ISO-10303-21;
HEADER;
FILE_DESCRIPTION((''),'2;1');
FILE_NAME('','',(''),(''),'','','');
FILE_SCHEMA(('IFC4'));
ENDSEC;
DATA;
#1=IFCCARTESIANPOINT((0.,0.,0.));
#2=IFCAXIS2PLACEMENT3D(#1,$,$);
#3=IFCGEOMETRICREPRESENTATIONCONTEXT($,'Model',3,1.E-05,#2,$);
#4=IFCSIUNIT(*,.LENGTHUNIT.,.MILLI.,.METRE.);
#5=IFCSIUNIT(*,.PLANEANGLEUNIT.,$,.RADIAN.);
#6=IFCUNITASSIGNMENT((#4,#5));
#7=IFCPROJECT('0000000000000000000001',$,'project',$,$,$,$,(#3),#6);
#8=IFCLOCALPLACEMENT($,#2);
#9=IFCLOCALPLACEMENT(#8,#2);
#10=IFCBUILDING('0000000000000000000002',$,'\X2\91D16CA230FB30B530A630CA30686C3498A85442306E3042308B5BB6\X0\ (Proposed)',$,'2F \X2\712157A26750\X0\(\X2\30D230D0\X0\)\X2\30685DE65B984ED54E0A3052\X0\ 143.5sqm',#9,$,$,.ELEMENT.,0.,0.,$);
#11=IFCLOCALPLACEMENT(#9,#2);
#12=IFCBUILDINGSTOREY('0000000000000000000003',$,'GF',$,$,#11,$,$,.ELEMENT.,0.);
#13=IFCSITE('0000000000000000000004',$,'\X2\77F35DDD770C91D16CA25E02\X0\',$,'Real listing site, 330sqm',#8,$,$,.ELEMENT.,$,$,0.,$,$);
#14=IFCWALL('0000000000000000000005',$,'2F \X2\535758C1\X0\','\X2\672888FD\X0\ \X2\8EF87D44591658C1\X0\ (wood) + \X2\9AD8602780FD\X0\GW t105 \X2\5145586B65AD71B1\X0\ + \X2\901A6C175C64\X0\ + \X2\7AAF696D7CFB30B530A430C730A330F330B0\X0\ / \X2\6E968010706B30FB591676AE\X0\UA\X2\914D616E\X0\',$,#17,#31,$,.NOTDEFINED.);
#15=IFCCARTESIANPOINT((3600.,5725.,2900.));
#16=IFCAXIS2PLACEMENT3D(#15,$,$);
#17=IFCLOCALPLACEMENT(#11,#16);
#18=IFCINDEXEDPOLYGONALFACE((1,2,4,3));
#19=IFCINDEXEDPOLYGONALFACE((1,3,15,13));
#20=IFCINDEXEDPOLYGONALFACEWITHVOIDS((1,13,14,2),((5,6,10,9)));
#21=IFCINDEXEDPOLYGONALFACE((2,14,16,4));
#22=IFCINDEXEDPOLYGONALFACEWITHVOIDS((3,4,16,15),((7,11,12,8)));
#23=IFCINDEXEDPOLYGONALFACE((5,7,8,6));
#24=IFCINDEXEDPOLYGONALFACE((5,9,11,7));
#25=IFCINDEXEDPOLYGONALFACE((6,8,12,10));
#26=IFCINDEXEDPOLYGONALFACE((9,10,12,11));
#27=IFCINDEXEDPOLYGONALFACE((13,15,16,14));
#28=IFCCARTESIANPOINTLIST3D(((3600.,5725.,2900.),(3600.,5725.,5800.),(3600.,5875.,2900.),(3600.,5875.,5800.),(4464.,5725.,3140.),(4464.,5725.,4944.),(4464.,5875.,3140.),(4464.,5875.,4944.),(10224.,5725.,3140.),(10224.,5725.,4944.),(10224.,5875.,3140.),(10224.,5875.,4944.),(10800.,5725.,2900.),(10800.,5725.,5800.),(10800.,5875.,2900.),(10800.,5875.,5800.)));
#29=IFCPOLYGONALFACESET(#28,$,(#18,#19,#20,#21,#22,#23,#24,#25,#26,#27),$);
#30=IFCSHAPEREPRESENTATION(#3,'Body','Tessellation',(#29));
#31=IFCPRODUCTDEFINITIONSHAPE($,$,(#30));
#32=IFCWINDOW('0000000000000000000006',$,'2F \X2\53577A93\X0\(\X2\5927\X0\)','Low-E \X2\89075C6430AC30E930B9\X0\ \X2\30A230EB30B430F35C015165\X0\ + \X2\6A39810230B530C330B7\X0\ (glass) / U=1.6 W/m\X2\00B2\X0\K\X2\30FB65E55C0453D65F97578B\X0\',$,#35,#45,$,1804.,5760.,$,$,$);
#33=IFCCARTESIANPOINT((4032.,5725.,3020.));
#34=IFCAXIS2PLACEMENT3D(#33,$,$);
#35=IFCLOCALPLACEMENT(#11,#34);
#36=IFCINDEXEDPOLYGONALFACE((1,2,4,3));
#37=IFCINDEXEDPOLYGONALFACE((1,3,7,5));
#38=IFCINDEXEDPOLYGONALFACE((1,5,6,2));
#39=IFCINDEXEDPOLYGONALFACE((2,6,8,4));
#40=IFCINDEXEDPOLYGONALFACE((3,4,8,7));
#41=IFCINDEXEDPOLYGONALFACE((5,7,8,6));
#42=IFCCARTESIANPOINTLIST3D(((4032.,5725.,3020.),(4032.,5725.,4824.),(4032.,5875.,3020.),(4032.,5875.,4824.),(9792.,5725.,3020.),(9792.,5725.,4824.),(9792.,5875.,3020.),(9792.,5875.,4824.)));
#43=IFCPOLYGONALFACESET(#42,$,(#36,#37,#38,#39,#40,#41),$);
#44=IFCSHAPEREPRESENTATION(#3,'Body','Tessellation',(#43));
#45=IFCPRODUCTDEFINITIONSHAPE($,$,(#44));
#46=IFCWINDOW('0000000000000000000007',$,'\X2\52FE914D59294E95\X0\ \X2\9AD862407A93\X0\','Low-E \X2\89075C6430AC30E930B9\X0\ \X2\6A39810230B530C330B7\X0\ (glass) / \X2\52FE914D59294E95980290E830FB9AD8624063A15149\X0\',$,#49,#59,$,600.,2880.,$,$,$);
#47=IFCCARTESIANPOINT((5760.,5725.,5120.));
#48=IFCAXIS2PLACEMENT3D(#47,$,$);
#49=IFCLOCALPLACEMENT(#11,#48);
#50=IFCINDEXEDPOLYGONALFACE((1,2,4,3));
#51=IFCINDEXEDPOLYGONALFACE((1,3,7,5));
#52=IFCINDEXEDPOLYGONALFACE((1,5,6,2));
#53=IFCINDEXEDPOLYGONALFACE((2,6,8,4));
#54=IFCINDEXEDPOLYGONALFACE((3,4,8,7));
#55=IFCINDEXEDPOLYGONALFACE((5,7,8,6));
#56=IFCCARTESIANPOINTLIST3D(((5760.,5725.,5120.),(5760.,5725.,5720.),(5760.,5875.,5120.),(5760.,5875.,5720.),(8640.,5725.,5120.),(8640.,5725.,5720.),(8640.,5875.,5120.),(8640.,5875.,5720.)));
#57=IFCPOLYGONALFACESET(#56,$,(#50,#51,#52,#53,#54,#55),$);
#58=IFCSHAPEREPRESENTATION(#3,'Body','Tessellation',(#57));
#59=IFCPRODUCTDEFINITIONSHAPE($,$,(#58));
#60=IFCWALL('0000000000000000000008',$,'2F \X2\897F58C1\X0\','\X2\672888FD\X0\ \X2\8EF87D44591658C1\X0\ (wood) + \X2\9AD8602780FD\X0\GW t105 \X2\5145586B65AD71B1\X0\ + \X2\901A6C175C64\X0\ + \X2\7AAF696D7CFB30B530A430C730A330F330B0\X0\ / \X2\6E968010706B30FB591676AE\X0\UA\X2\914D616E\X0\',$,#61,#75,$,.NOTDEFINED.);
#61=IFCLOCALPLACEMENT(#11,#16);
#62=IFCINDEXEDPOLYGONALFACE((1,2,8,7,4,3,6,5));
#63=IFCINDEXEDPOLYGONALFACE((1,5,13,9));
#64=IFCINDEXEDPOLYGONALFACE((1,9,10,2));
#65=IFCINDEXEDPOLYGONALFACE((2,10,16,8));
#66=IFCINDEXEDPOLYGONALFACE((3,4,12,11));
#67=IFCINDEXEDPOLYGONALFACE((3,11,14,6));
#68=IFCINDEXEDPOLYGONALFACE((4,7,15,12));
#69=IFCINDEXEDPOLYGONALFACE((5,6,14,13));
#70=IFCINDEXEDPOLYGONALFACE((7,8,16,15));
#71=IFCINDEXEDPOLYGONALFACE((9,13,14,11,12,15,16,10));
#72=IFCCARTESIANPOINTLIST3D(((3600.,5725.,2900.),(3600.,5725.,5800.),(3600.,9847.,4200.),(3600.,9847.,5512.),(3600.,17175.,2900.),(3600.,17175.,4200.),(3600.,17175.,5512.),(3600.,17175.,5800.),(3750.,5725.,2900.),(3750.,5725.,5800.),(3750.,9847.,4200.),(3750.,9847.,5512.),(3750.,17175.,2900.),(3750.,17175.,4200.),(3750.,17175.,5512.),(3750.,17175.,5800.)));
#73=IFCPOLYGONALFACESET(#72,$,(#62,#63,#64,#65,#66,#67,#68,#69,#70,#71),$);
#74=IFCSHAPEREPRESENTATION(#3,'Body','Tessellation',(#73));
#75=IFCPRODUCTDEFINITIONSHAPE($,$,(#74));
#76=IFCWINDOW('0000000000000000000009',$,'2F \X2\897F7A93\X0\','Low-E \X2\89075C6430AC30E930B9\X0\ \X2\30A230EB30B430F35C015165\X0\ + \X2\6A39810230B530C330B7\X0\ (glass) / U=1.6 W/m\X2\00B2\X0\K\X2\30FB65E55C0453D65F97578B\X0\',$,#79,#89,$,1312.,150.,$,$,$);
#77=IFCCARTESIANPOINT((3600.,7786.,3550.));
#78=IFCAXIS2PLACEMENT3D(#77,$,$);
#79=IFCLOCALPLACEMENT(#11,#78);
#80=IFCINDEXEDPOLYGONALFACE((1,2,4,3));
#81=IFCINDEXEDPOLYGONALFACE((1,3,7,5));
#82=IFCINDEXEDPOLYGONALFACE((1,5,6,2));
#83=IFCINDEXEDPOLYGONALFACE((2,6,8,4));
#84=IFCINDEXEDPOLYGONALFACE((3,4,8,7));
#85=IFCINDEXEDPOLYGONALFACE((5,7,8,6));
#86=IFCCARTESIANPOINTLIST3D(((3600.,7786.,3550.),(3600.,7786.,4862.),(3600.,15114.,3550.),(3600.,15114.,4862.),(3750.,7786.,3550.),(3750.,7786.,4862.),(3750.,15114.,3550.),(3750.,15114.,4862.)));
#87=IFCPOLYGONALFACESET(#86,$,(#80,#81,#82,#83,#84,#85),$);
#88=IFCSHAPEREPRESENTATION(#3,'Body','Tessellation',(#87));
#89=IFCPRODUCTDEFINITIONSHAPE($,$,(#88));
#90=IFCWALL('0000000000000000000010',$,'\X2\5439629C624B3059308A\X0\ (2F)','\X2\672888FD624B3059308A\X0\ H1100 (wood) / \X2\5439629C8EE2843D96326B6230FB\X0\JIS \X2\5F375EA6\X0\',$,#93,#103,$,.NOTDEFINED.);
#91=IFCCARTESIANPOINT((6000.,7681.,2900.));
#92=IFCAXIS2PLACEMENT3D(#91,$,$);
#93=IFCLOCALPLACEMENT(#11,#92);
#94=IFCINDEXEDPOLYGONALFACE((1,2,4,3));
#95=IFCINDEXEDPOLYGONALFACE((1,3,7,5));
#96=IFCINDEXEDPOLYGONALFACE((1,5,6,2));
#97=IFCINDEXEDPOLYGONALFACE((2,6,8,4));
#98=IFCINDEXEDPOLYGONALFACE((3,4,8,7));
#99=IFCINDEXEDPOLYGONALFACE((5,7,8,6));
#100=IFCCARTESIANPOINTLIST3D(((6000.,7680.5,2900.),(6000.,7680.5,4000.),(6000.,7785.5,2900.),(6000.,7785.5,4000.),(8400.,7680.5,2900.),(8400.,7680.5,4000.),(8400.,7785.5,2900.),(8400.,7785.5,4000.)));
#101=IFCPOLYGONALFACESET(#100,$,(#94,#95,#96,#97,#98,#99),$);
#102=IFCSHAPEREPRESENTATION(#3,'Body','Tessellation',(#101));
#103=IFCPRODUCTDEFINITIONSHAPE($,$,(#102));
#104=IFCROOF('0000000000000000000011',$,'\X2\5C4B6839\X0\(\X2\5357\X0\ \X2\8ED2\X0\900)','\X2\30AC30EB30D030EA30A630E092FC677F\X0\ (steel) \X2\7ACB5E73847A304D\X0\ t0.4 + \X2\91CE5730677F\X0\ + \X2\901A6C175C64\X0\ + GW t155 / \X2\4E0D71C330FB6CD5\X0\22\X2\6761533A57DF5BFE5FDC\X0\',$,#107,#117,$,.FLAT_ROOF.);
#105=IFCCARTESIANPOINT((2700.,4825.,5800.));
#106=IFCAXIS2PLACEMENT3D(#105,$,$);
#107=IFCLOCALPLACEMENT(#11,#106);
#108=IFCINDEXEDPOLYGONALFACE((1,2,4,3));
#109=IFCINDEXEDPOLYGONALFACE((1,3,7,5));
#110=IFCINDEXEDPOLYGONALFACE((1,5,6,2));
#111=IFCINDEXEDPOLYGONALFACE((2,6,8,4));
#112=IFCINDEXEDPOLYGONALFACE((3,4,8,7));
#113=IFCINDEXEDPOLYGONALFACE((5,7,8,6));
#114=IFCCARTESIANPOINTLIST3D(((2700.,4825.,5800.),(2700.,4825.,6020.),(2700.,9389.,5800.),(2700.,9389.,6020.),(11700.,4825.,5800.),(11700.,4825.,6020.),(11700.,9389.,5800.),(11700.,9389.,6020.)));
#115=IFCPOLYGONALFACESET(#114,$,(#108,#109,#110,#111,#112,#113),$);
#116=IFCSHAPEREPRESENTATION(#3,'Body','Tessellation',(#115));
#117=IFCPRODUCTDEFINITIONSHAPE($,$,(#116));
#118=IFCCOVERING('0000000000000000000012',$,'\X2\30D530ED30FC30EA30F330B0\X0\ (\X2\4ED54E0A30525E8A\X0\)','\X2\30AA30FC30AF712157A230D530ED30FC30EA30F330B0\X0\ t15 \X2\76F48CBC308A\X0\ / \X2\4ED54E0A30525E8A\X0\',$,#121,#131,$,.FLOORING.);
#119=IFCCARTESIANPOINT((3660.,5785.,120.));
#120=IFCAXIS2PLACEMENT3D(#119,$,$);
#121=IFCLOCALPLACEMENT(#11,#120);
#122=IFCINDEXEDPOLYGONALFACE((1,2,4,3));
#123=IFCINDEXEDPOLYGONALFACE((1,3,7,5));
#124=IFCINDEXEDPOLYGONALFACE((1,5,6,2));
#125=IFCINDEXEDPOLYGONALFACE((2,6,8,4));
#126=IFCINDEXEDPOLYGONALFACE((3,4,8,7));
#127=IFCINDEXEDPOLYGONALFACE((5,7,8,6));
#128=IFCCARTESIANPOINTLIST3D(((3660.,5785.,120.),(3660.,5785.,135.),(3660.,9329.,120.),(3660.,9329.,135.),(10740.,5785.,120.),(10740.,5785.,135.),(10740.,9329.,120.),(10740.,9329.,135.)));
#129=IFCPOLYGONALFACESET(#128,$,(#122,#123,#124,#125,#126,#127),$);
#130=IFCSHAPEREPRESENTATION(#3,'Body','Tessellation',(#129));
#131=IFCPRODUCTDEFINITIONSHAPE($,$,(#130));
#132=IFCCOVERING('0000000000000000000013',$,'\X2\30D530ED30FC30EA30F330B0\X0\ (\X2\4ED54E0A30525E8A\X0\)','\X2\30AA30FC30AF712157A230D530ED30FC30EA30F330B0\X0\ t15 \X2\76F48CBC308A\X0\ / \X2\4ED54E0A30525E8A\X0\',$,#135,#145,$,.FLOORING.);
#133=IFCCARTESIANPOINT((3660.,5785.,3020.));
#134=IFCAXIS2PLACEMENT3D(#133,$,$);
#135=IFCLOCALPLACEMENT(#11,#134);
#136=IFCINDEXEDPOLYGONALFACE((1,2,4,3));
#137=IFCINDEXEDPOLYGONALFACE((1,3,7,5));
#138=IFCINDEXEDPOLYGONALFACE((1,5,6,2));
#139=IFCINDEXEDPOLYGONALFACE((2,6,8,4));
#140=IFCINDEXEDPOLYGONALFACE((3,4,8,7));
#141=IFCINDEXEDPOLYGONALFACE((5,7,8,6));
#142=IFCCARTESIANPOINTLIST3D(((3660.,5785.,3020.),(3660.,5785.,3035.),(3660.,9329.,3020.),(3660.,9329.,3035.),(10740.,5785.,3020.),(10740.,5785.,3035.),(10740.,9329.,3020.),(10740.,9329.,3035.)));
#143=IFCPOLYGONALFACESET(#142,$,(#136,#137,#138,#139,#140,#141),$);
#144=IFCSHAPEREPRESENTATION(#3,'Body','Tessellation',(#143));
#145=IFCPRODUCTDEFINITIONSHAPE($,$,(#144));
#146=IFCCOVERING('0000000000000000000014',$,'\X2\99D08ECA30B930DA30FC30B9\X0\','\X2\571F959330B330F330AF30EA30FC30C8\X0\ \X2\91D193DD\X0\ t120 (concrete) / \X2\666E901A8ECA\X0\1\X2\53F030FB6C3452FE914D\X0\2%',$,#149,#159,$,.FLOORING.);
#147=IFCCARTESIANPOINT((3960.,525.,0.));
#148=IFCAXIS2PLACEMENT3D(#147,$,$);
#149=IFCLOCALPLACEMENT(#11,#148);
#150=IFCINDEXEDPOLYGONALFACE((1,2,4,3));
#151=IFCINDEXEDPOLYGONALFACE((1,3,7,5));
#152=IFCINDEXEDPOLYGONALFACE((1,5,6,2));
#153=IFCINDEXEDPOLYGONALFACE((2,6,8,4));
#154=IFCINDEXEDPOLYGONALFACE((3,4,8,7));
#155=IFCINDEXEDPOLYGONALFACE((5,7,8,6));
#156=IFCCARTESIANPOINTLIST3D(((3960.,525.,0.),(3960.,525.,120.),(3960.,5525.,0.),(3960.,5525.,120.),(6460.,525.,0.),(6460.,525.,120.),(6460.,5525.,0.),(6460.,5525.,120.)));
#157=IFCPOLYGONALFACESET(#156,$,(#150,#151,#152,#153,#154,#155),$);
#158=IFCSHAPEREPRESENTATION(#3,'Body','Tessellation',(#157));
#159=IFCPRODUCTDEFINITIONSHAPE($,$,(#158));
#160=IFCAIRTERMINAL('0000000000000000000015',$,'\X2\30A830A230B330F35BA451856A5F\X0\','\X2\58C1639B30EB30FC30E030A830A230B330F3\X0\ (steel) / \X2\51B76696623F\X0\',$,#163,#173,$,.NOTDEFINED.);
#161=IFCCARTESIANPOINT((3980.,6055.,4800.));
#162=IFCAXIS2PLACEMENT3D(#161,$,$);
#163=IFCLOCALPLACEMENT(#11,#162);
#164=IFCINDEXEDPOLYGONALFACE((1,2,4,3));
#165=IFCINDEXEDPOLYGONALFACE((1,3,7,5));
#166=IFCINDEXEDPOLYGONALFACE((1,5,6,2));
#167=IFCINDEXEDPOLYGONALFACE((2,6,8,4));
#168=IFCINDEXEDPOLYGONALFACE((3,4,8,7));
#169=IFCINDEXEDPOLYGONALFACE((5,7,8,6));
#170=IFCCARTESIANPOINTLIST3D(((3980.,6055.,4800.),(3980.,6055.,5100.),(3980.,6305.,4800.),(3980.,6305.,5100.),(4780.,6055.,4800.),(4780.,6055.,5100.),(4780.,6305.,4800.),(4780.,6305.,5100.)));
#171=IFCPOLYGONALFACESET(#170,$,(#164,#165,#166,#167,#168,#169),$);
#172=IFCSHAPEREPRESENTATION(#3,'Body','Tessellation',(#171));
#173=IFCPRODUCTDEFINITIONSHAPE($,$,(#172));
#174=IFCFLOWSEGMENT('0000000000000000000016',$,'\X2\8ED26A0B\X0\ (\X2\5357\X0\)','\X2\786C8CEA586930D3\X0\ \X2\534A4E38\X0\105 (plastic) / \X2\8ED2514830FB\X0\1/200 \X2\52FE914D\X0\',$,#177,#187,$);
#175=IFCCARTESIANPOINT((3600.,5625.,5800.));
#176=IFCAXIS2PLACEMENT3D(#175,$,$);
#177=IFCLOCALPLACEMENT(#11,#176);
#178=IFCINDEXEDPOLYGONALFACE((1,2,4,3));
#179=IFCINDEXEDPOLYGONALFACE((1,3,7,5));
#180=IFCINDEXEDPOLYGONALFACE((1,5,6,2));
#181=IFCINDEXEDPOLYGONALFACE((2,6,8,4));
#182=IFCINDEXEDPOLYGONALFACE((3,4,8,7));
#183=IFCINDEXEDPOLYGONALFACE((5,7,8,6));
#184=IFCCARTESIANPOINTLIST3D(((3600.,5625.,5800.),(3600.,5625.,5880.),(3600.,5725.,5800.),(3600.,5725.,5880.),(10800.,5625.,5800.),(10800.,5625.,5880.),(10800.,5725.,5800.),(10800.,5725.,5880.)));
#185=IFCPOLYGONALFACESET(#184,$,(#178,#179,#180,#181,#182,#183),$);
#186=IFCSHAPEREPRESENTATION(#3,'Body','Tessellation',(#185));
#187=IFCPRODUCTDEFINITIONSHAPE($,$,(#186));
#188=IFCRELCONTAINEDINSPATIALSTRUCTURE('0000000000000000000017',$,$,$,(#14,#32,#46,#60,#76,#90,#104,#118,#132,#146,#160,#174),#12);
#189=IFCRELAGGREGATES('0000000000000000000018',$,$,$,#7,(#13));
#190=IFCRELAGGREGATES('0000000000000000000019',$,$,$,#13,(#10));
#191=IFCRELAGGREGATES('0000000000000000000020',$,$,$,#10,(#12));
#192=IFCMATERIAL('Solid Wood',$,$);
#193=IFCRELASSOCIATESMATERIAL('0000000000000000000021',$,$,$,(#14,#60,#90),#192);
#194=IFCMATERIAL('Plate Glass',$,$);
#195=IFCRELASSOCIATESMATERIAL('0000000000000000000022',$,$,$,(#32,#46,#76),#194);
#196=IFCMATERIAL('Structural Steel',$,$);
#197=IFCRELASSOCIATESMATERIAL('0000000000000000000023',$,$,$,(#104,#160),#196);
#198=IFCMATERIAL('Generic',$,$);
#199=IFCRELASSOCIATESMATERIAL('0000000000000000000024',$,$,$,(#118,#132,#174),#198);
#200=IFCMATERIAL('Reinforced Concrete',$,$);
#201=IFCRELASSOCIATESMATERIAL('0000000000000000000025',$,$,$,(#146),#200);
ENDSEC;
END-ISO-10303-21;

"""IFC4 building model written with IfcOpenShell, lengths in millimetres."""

from ifc_helpers import new_model, si_unit, frame, frame_2d, origin, place, context, project, spatial, rectangle, extrude, material, element, fill, save


model = new_model("IFC4")

# Units and contexts
model_context = context("Model", 3, precision=1e-05, world=origin())
ifc_project = project(units=[si_unit("LENGTHUNIT", "METRE", prefix="MILLI"), si_unit("PLANEANGLEUNIT", "RADIAN")], contexts=[model_context])

# Site, building, storey
site_placement = place(None, origin())
site = spatial("IfcSite", under=ifc_project, at=site_placement, Name="石川県金沢市", ObjectType="Real listing site, 330sqm", CompositionType="ELEMENT", RefElevation=0.0)
building_placement = place(site_placement, origin())
building = spatial("IfcBuilding", under=site, at=building_placement, Name="金沢・サウナと水風呂のある家 (Proposed)", ObjectType="2F 無垢材(ヒバ)と左官仕上げ 143.5sqm", CompositionType="ELEMENT", ElevationOfRefHeight=0.0, ElevationOfTerrain=0.0)
storey_placement = place(building_placement, origin())
storey = spatial("IfcBuildingStorey", under=building, at=storey_placement, Name="GF", CompositionType="ELEMENT", Elevation=0.0)

# Shared definitions
ifc_material_1 = material(Name="Solid Wood")

# Shared definitions
ifc_material_2 = material(Name="Reinforced Concrete")

# Shared definitions
ifc_material_3 = material(Name="Plate Glass")

# Wall, openings, windows
wall_1_placement = place(storey_placement, frame((3600.0, 5725.0, 2900.0)))
wall_1 = element("IfcWall", 1, at=wall_1_placement, inside=storey, material=ifc_material_1, Name="2F 南壁", Description="木製 軸組外壁 (wood) + 高性能GW t105 充填断熱 + 通気層 + 窯業系サイディング / 準耐火・外皮UA配慮", PredefinedType="NOTDEFINED", context=model_context, shape_type="SweptSolid", body=[
    extrude(rectangle(XDim=7200.0, YDim=150.0, at=frame_2d((3600.0, 75.0))), frame((3600.0, 5725.0, 2900.0)), (0.0, 0.0, 1.0), 2900.0),
])
opening_1_placement = place(storey_placement, frame((4032.0, 5725.0, 3020.0)))
opening_1 = element("IfcOpeningElement", 2, at=opening_1_placement, cuts=wall_1, PredefinedType="NOTDEFINED", context=model_context, shape_type="SweptSolid", body=[
    extrude(rectangle(XDim=5760.0, YDim=150.0, at=frame_2d((2880.0, 75.0))), frame((4032.0, 5725.0, 3020.0)), (0.0, 0.0, 1.0), 1804.0),
])
opening_2_placement = place(storey_placement, frame((5760.0, 5725.0, 5120.0)))
opening_2 = element("IfcOpeningElement", 3, at=opening_2_placement, cuts=wall_1, PredefinedType="NOTDEFINED", context=model_context, shape_type="SweptSolid", body=[
    extrude(rectangle(XDim=2880.0, YDim=150.0, at=frame_2d((1440.0, 75.0))), frame((5760.0, 5725.0, 5120.0)), (0.0, 0.0, 1.0), 600.0),
])
window_1_placement = place(storey_placement, frame((4032.0, 5725.0, 3020.0)))
window_1 = element("IfcWindow", 4, at=window_1_placement, inside=storey, material=ifc_material_3, Name="2F 南窓(大)", Description="Low-E 複層ガラス アルゴン封入 + 樹脂サッシ (glass) / U=1.6 W/m²K・日射取得型", OverallHeight=1804.0, OverallWidth=5760.0, context=model_context, shape_type="SweptSolid", body=[
    extrude(rectangle(XDim=5760.0, YDim=150.0, at=frame_2d((2880.0, 75.0))), frame((4032.0, 5725.0, 3020.0)), (0.0, 0.0, 1.0), 1804.0),
])
fill(opening_1, window_1)
window_2_placement = place(storey_placement, frame((5760.0, 5725.0, 5120.0)))
window_2 = element("IfcWindow", 5, at=window_2_placement, inside=storey, material=ifc_material_3, Name="勾配天井 高所窓", Description="Low-E 複層ガラス 樹脂サッシ (glass) / 勾配天井頂部・高所採光", OverallHeight=600.0, OverallWidth=2880.0, context=model_context, shape_type="SweptSolid", body=[
    extrude(rectangle(XDim=2880.0, YDim=150.0, at=frame_2d((1440.0, 75.0))), frame((5760.0, 5725.0, 5120.0)), (0.0, 0.0, 1.0), 600.0),
])
fill(opening_2, window_2)

# Wall, opening, window
wall_2_placement = place(storey_placement, frame((3600.0, 5725.0, 2900.0)))
wall_2 = element("IfcWall", 6, at=wall_2_placement, inside=storey, material=ifc_material_1, Name="2F 西壁", Description="木製 軸組外壁 (wood) + 高性能GW t105 充填断熱 + 通気層 + 窯業系サイディング / 準耐火・外皮UA配慮", PredefinedType="NOTDEFINED", context=model_context, shape_type="SweptSolid", body=[
    extrude(rectangle(XDim=150.0, YDim=11450.0, at=frame_2d((75.0, 5725.0))), frame((3600.0, 5725.0, 2900.0)), (0.0, 0.0, 1.0), 2900.0),
])
opening_3_placement = place(storey_placement, frame((3600.0, 7786.0, 3550.0)))
opening_3 = element("IfcOpeningElement", 7, at=opening_3_placement, cuts=wall_2, PredefinedType="NOTDEFINED", context=model_context, shape_type="SweptSolid", body=[
    extrude(rectangle(XDim=150.0, YDim=7328.0, at=frame_2d((75.0, 3664.0))), frame((3600.0, 7786.0, 3550.0)), (0.0, 0.0, 1.0), 1312.0),
])
window_3_placement = place(storey_placement, frame((3600.0, 7786.0, 3550.0)))
window_3 = element("IfcWindow", 8, at=window_3_placement, inside=storey, material=ifc_material_3, Name="2F 西窓", Description="Low-E 複層ガラス アルゴン封入 + 樹脂サッシ (glass) / U=1.6 W/m²K・日射取得型", OverallHeight=1312.0, OverallWidth=150.0, context=model_context, shape_type="SweptSolid", body=[
    extrude(rectangle(XDim=150.0, YDim=7328.0, at=frame_2d((75.0, 3664.0))), frame((3600.0, 7786.0, 3550.0)), (0.0, 0.0, 1.0), 1312.0),
])
fill(opening_3, window_3)

# Wall
wall_3_placement = place(storey_placement, frame((6000.0, 7681.0, 2900.0)))
element("IfcWall", 9, at=wall_3_placement, inside=storey, material=ifc_material_1, Name="吹抜手すり (2F)", Description="木製手すり H1100 (wood) / 吹抜転落防止・JIS 強度", PredefinedType="NOTDEFINED", context=model_context, shape_type="SweptSolid", body=[
    extrude(rectangle(XDim=2400.0, YDim=105.0, at=frame_2d((1200.0, 52.0))), frame((6000.0, 7681.0, 2900.0)), (0.0, 0.0, 1.0), 1100.0),
])

# Roof
ifc_material_4 = material(Name="Structural Steel")
for number, where, name in (
    (10, (2700.0, 4825.0, 5800.0), "屋根(南 軒900)"),
):
    element("IfcRoof", number, at=place(storey_placement, frame(where)), inside=storey, material=ifc_material_4, Name=name, Description="ガルバリウム鋼板 (steel) 立平葺き t0.4 + 野地板 + 通気層 + GW t155 / 不燃・法22条区域対応", PredefinedType="FLAT_ROOF", context=model_context, shape_type="SweptSolid", body=[
        extrude(rectangle(XDim=9000.0, YDim=4564.0, at=frame_2d((4500.0, 2282.0))), frame((2700.0, 4825.0, 5800.0)), (0.0, 0.0, 1.0), 220.0),
    ])

# Coverings
ifc_material_5 = material(Name="Generic")
covering_1_placement = place(storey_placement, frame((3660.0, 5785.0, 120.0)))
element("IfcCovering", 11, at=covering_1_placement, inside=storey, material=ifc_material_5, Name="フローリング (仕上げ床)", Description="オーク無垢フローリング t15 直貼り / 仕上げ床", PredefinedType="FLOORING", context=model_context, shape_type="SweptSolid", body=[
    extrude(rectangle(XDim=7080.0, YDim=3544.0, at=frame_2d((3540.0, 1772.0))), frame((3660.0, 5785.0, 120.0)), (0.0, 0.0, 1.0), 15.0),
])
covering_2_placement = place(storey_placement, frame((3660.0, 5785.0, 3020.0)))
element("IfcCovering", 12, at=covering_2_placement, inside=storey, material=ifc_material_5, Name="フローリング (仕上げ床)", Description="オーク無垢フローリング t15 直貼り / 仕上げ床", PredefinedType="FLOORING", context=model_context, shape_type="SweptSolid", body=[
    extrude(rectangle(XDim=7080.0, YDim=3544.0, at=frame_2d((3540.0, 1772.0))), frame((3660.0, 5785.0, 3020.0)), (0.0, 0.0, 1.0), 15.0),
])
covering_3_placement = place(storey_placement, frame((3960.0, 525.0, 0.0)))
element("IfcCovering", 13, at=covering_3_placement, inside=storey, material=ifc_material_2, Name="駐車スペース", Description="土間コンクリート 金鏝 t120 (concrete) / 普通車1台・水勾配2%", PredefinedType="FLOORING", context=model_context, shape_type="SweptSolid", body=[
    extrude(rectangle(XDim=2500.0, YDim=5000.0, at=frame_2d((1250.0, 2500.0))), frame((3960.0, 525.0, 0.0)), (0.0, 0.0, 1.0), 120.0),
])

# Air terminal
air_terminal_placement = place(storey_placement, frame((3980.0, 6055.0, 4800.0)))
element("IfcAirTerminal", 14, at=air_terminal_placement, inside=storey, material=ifc_material_4, Name="エアコン室内機", Description="壁掛ルームエアコン (steel) / 冷暖房", PredefinedType="NOTDEFINED", context=model_context, shape_type="SweptSolid", body=[
    extrude(rectangle(XDim=800.0, YDim=250.0, at=frame_2d((400.0, 125.0))), frame((3980.0, 6055.0, 4800.0)), (0.0, 0.0, 1.0), 300.0),
])

# Flow segment
flow_segment_1_placement = place(storey_placement, frame((3600.0, 5625.0, 5800.0)))
element("IfcFlowSegment", 15, at=flow_segment_1_placement, inside=storey, material=ifc_material_5, Name="軒樋 (南)", Description="硬質塩ビ 半丸105 (plastic) / 軒先・1/200 勾配", context=model_context, shape_type="SweptSolid", body=[
    extrude(rectangle(XDim=7200.0, YDim=100.0, at=frame_2d((3600.0, 50.0))), frame((3600.0, 5625.0, 5800.0)), (0.0, 0.0, 1.0), 80.0),
])

save(model, "model.ifc")
